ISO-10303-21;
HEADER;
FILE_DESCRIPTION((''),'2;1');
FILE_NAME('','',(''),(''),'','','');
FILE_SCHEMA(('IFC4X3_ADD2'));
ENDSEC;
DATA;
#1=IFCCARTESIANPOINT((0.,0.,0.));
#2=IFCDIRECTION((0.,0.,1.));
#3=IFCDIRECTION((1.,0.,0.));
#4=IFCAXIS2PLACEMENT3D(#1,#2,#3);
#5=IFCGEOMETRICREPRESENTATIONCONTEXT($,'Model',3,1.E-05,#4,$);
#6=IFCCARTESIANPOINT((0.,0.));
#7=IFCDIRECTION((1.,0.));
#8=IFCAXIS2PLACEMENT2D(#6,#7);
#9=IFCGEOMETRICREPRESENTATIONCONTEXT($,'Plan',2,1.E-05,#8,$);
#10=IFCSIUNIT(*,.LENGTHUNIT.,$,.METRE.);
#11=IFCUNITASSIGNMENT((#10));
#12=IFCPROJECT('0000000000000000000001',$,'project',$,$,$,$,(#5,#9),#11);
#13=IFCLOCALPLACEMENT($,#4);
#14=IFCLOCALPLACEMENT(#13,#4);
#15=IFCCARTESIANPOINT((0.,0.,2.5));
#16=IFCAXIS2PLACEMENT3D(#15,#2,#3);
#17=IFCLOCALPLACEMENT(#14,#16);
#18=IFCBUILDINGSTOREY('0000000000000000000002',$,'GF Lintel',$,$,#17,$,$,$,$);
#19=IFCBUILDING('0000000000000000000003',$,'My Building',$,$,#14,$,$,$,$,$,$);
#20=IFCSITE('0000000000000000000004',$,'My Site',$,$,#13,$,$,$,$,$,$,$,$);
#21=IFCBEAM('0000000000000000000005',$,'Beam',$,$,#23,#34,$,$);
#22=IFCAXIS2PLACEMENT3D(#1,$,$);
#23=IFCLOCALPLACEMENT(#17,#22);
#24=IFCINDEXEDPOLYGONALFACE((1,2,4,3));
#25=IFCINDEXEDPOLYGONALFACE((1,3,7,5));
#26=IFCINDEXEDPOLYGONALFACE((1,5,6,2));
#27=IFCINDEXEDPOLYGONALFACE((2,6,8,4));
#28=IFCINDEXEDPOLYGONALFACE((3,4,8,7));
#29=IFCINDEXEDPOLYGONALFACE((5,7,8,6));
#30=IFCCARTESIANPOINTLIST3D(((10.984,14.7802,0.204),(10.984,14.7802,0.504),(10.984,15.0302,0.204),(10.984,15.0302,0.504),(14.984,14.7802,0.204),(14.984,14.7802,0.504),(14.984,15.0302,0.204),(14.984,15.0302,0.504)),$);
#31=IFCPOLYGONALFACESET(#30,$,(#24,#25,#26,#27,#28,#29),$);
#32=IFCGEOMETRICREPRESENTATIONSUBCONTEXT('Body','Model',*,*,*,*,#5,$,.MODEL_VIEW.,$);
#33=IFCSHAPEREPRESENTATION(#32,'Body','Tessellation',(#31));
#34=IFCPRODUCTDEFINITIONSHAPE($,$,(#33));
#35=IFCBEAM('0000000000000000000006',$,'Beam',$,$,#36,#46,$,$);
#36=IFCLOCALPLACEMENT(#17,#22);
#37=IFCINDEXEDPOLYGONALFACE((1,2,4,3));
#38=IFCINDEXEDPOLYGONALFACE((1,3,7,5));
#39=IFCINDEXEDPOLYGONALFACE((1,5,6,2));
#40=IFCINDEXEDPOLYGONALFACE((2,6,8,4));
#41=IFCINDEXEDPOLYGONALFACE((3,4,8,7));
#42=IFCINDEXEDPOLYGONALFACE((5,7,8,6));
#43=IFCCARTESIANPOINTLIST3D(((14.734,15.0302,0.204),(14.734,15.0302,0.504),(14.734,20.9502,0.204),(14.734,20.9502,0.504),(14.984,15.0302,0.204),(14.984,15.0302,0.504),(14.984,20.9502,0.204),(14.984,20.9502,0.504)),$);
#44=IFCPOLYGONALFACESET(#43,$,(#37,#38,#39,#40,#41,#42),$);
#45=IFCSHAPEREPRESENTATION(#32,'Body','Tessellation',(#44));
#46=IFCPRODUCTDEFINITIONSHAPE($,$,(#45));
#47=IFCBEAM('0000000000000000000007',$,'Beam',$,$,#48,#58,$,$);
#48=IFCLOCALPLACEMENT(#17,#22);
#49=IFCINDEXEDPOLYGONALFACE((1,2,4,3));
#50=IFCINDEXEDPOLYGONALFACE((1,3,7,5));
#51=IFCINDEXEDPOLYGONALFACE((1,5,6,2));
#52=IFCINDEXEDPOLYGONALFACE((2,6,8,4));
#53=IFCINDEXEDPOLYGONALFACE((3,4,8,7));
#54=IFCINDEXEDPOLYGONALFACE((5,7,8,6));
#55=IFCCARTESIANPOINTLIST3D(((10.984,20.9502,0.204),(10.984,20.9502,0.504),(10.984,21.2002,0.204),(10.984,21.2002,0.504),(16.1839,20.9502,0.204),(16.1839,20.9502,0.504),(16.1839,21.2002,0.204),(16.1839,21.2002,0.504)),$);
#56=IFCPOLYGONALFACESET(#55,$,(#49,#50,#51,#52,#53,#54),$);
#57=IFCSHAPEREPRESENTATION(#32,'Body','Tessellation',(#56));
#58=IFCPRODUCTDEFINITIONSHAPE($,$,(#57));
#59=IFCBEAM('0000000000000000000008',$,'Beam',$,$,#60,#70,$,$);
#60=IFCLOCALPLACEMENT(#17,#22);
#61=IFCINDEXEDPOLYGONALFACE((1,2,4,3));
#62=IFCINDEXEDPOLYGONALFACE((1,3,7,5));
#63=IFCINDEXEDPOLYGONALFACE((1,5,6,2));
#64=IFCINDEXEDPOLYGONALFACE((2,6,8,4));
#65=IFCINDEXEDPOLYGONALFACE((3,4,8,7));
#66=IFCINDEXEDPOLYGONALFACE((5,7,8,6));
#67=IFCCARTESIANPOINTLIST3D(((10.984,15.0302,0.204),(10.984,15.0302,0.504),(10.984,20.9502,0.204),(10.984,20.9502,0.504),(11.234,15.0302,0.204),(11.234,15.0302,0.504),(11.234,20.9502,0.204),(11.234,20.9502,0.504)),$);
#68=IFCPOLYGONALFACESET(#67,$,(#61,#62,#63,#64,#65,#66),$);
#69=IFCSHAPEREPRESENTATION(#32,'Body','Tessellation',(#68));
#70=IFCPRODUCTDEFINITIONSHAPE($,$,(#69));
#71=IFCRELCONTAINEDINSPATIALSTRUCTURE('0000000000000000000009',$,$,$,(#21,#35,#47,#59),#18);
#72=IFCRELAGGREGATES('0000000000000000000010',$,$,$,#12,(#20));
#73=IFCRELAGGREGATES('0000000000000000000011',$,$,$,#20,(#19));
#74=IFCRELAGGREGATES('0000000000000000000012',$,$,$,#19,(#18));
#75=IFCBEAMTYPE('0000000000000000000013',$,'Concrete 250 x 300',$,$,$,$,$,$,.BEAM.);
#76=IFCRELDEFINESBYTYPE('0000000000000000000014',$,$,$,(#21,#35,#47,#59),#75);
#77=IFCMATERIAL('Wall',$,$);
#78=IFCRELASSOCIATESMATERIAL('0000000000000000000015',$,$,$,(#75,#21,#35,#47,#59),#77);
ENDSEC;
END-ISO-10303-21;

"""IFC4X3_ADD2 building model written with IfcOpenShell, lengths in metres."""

from ifc_helpers import new_model, si_unit, frame, origin_with_axes, origin_2d_with_axis, place, context, subcontext, project, spatial, rectangle, extrude, material, material_profile, profile_set, profile_usage, type_object, element, save


model = new_model("IFC4X3_ADD2")

# Units and contexts
model_context = context("Model", 3, precision=1e-05, world=origin_with_axes())
plan_context = context("Plan", 2, precision=1e-05, world=origin_2d_with_axis())
body_context = subcontext(model_context, "Body", "Model", "MODEL_VIEW")
ifc_project = project(units=[si_unit("LENGTHUNIT", "METRE")], contexts=[model_context, plan_context])

# Site, building, storey
site_placement = place(None, origin_with_axes())
site = spatial("IfcSite", under=ifc_project, at=site_placement, Name="My Site")
building_placement = place(site_placement, origin_with_axes())
building = spatial("IfcBuilding", under=site, at=building_placement, Name="My Building")
storey_placement = place(building_placement, frame((0.0, 0.0, 2.5), z_axis=(0.0, 0.0, 1.0), x_axis=(1.0, 0.0, 0.0)))
storey = spatial("IfcBuildingStorey", under=building, at=storey_placement, Name="GF Lintel")

# Beams
ifc_material = material(Name="Wall")
ifc_material_profile = material_profile(ifc_material, rectangle(XDim=0.25, YDim=0.3))
ifc_profile_set = profile_set([ifc_material_profile])
ifc_profile_usage_1 = profile_usage(ifc_profile_set, cardinal=5)
beam_type = type_object("IfcBeamType", Name="Concrete 250 x 300", PredefinedType="BEAM", material=ifc_profile_set)
beam_1_placement = place(storey_placement, frame((10.984, 14.9052, 0.354), z_axis=(1.0, 0.0, 0.0), x_axis=(0.0, 1.0, 0.0)))
element("IfcBeam", 1, at=beam_1_placement, inside=storey, type_object=beam_type, material=ifc_profile_usage_1, Name="Beam", context=body_context, shape_type="SweptSolid", body=[
    extrude(rectangle(XDim=0.25, YDim=0.3), origin_with_axes(), (0.0, 0.0, 1.0), 4.0),
])
ifc_profile_usage_2 = profile_usage(ifc_profile_set, cardinal=5)
beam_2_placement = place(storey_placement, frame((14.859, 15.0302, 0.354), z_axis=(0.0, 1.0, 0.0), x_axis=(-1.0, 0.0, 0.0)))
element("IfcBeam", 2, at=beam_2_placement, inside=storey, type_object=beam_type, material=ifc_profile_usage_2, Name="Beam", context=body_context, shape_type="SweptSolid", body=[
    extrude(rectangle(XDim=0.25, YDim=0.3), origin_with_axes(), (0.0, 0.0, 1.0), 5.92),
])
ifc_profile_usage_3 = profile_usage(ifc_profile_set, cardinal=5)
beam_3_placement = place(storey_placement, frame((10.984, 21.0752, 0.354), z_axis=(1.0, 0.0, 0.0), x_axis=(0.0, 1.0, 0.0)))
element("IfcBeam", 3, at=beam_3_placement, inside=storey, type_object=beam_type, material=ifc_profile_usage_3, Name="Beam", context=body_context, shape_type="SweptSolid", body=[
    extrude(rectangle(XDim=0.25, YDim=0.3), origin_with_axes(), (0.0, 0.0, 1.0), 5.2),
])
ifc_profile_usage_4 = profile_usage(ifc_profile_set, cardinal=5)
beam_4_placement = place(storey_placement, frame((11.109, 15.0302, 0.354), z_axis=(0.0, 1.0, 0.0), x_axis=(-1.0, 0.0, 0.0)))
element("IfcBeam", 4, at=beam_4_placement, inside=storey, type_object=beam_type, material=ifc_profile_usage_4, Name="Beam", context=body_context, shape_type="SweptSolid", body=[
    extrude(rectangle(XDim=0.25, YDim=0.3), origin_with_axes(), (0.0, 0.0, 1.0), 5.92),
])

save(model, "model.ifc")
